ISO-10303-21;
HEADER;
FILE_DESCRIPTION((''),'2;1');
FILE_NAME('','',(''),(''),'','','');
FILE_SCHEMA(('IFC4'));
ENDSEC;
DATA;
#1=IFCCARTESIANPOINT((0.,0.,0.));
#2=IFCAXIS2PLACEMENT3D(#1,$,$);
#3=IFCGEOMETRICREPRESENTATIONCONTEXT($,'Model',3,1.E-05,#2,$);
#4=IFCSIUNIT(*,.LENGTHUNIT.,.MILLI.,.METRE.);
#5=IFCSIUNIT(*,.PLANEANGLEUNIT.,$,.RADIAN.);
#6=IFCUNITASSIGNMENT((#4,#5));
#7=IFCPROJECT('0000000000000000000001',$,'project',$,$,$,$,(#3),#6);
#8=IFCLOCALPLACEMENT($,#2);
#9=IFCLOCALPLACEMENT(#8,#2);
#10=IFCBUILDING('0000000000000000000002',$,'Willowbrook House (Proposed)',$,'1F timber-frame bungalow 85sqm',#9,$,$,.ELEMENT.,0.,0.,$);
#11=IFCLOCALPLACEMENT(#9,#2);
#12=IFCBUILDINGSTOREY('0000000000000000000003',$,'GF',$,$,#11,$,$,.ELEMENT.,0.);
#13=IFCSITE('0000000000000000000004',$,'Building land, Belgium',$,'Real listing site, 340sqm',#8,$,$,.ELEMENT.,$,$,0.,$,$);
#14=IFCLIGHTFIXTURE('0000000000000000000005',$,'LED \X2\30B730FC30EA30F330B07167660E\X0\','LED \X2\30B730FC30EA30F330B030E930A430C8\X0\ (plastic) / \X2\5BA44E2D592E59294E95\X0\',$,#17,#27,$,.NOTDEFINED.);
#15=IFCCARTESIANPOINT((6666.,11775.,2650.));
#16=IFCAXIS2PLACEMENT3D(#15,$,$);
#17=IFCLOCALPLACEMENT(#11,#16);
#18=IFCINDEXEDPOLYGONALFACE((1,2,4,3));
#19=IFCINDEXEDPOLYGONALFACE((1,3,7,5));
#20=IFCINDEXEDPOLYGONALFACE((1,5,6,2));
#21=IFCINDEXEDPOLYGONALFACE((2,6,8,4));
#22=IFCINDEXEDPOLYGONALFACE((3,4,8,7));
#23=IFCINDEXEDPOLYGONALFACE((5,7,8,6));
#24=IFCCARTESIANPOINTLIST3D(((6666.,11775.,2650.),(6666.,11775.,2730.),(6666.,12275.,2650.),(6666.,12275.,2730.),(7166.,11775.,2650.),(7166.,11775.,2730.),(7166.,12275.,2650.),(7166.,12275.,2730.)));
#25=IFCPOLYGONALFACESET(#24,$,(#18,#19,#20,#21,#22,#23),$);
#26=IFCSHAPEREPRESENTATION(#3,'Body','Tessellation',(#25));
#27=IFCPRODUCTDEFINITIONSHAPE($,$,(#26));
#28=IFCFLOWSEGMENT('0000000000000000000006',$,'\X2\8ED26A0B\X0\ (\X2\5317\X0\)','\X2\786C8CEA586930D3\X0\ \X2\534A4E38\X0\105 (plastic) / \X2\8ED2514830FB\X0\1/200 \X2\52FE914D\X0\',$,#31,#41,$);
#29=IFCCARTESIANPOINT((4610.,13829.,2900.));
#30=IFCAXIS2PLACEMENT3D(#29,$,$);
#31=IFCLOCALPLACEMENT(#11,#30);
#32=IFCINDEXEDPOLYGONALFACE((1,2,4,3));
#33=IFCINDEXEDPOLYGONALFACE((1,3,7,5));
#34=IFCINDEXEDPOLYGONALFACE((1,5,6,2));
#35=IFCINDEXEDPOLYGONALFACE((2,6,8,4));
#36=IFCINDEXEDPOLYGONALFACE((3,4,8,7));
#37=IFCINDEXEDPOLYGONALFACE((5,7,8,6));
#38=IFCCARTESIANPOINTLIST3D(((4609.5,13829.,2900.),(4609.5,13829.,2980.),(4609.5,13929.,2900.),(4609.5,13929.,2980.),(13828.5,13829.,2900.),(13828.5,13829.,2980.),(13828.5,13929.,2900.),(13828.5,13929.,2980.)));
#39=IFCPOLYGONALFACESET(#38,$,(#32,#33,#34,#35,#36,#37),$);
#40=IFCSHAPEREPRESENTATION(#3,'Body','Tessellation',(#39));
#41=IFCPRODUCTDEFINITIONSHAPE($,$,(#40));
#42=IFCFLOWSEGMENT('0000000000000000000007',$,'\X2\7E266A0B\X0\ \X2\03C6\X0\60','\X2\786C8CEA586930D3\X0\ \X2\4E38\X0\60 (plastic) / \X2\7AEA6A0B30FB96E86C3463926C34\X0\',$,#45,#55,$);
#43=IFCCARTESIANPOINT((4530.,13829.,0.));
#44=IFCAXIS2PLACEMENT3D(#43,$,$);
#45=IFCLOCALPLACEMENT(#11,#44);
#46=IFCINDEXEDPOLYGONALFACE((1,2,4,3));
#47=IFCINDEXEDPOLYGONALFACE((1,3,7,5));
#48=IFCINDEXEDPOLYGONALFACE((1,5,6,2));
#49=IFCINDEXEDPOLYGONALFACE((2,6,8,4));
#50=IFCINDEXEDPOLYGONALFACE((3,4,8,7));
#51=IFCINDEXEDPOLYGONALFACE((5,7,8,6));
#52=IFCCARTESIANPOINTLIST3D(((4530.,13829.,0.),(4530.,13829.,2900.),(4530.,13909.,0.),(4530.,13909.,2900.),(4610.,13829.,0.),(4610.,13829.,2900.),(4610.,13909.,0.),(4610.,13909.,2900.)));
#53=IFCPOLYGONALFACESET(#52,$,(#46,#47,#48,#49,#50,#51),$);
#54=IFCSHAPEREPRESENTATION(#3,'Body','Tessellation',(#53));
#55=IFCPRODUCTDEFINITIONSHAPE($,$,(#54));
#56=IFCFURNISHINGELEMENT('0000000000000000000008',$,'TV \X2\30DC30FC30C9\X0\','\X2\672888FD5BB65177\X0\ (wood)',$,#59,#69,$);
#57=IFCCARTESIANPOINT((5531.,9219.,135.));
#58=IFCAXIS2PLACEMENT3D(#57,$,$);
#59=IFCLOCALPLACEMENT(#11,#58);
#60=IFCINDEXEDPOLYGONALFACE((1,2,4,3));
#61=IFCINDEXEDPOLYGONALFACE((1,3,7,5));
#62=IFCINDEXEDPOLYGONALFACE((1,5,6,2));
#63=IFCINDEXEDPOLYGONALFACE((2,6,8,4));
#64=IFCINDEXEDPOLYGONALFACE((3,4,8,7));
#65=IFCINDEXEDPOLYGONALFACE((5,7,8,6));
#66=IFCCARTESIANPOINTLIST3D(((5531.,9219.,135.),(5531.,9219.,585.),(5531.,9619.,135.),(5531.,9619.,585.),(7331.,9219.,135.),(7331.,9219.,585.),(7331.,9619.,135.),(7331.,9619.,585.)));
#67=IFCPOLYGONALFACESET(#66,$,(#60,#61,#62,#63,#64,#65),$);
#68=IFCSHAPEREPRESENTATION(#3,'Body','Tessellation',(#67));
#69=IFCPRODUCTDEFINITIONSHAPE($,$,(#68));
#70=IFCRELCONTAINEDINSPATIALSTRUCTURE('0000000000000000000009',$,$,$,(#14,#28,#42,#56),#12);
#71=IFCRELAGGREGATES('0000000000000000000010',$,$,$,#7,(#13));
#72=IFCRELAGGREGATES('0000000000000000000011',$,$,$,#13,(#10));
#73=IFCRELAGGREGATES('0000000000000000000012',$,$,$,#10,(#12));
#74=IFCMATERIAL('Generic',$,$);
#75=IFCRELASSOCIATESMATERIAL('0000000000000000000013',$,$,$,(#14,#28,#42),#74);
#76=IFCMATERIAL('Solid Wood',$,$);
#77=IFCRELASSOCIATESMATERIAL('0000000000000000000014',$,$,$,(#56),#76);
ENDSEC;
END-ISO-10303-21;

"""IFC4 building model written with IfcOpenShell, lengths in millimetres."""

from ifc_helpers import new_model, si_unit, frame, frame_2d, origin, place, context, project, spatial, rectangle, extrude, material, element, save


model = new_model("IFC4")

# Units and contexts
model_context = context("Model", 3, precision=1e-05, world=origin())
ifc_project = project(units=[si_unit("LENGTHUNIT", "METRE", prefix="MILLI"), si_unit("PLANEANGLEUNIT", "RADIAN")], contexts=[model_context])

# Site, building, storey
site_placement = place(None, origin())
site = spatial("IfcSite", under=ifc_project, at=site_placement, Name="Building land, Belgium", ObjectType="Real listing site, 340sqm", CompositionType="ELEMENT", RefElevation=0.0)
building_placement = place(site_placement, origin())
building = spatial("IfcBuilding", under=site, at=building_placement, Name="Willowbrook House (Proposed)", ObjectType="1F timber-frame bungalow 85sqm", CompositionType="ELEMENT", ElevationOfRefHeight=0.0, ElevationOfTerrain=0.0)
storey_placement = place(building_placement, origin())
storey = spatial("IfcBuildingStorey", under=building, at=storey_placement, Name="GF", CompositionType="ELEMENT", Elevation=0.0)

# Shared definitions
ifc_material_1 = material(Name="Solid Wood")

# Shared definitions
ifc_material_2 = material(Name="Generic")

# Light fixture
light_fixture_placement = place(storey_placement, frame((6666.0, 11775.0, 2650.0)))
element("IfcLightFixture", 1, at=light_fixture_placement, inside=storey, material=ifc_material_2, Name="LED シーリング照明", Description="LED シーリングライト (plastic) / 室中央天井", PredefinedType="NOTDEFINED", context=model_context, shape_type="SweptSolid", body=[
    extrude(rectangle(XDim=500.0, YDim=500.0, at=frame_2d((250.0, 250.0))), frame((6666.0, 11775.0, 2650.0)), (0.0, 0.0, 1.0), 80.0),
])

# Flow segments
flow_segment_1_placement = place(storey_placement, frame((4610.0, 13829.0, 2900.0)))
element("IfcFlowSegment", 2, at=flow_segment_1_placement, inside=storey, material=ifc_material_2, Name="軒樋 (北)", Description="硬質塩ビ 半丸105 (plastic) / 軒先・1/200 勾配", context=model_context, shape_type="SweptSolid", body=[
    extrude(rectangle(XDim=9219.0, YDim=100.0, at=frame_2d((4609.0, 50.0))), frame((4610.0, 13829.0, 2900.0)), (0.0, 0.0, 1.0), 80.0),
])
flow_segment_2_placement = place(storey_placement, frame((4530.0, 13829.0, 0.0)))
element("IfcFlowSegment", 3, at=flow_segment_2_placement, inside=storey, material=ifc_material_2, Name="縦樋 φ60", Description="硬質塩ビ 丸60 (plastic) / 竪樋・雨水排水", context=model_context, shape_type="SweptSolid", body=[
    extrude(rectangle(XDim=80.0, YDim=80.0, at=frame_2d((40.0, 40.0))), frame((4530.0, 13829.0, 0.0)), (0.0, 0.0, 1.0), 2900.0),
])

# Furnishing element
furnishing_placement = place(storey_placement, frame((5531.0, 9219.0, 135.0)))
element("IfcFurnishingElement", 4, at=furnishing_placement, inside=storey, material=ifc_material_1, Name="TV ボード", Description="木製家具 (wood)", context=model_context, shape_type="SweptSolid", body=[
    extrude(rectangle(XDim=1800.0, YDim=400.0, at=frame_2d((900.0, 200.0))), frame((5531.0, 9219.0, 135.0)), (0.0, 0.0, 1.0), 450.0),
])

save(model, "model.ifc")
